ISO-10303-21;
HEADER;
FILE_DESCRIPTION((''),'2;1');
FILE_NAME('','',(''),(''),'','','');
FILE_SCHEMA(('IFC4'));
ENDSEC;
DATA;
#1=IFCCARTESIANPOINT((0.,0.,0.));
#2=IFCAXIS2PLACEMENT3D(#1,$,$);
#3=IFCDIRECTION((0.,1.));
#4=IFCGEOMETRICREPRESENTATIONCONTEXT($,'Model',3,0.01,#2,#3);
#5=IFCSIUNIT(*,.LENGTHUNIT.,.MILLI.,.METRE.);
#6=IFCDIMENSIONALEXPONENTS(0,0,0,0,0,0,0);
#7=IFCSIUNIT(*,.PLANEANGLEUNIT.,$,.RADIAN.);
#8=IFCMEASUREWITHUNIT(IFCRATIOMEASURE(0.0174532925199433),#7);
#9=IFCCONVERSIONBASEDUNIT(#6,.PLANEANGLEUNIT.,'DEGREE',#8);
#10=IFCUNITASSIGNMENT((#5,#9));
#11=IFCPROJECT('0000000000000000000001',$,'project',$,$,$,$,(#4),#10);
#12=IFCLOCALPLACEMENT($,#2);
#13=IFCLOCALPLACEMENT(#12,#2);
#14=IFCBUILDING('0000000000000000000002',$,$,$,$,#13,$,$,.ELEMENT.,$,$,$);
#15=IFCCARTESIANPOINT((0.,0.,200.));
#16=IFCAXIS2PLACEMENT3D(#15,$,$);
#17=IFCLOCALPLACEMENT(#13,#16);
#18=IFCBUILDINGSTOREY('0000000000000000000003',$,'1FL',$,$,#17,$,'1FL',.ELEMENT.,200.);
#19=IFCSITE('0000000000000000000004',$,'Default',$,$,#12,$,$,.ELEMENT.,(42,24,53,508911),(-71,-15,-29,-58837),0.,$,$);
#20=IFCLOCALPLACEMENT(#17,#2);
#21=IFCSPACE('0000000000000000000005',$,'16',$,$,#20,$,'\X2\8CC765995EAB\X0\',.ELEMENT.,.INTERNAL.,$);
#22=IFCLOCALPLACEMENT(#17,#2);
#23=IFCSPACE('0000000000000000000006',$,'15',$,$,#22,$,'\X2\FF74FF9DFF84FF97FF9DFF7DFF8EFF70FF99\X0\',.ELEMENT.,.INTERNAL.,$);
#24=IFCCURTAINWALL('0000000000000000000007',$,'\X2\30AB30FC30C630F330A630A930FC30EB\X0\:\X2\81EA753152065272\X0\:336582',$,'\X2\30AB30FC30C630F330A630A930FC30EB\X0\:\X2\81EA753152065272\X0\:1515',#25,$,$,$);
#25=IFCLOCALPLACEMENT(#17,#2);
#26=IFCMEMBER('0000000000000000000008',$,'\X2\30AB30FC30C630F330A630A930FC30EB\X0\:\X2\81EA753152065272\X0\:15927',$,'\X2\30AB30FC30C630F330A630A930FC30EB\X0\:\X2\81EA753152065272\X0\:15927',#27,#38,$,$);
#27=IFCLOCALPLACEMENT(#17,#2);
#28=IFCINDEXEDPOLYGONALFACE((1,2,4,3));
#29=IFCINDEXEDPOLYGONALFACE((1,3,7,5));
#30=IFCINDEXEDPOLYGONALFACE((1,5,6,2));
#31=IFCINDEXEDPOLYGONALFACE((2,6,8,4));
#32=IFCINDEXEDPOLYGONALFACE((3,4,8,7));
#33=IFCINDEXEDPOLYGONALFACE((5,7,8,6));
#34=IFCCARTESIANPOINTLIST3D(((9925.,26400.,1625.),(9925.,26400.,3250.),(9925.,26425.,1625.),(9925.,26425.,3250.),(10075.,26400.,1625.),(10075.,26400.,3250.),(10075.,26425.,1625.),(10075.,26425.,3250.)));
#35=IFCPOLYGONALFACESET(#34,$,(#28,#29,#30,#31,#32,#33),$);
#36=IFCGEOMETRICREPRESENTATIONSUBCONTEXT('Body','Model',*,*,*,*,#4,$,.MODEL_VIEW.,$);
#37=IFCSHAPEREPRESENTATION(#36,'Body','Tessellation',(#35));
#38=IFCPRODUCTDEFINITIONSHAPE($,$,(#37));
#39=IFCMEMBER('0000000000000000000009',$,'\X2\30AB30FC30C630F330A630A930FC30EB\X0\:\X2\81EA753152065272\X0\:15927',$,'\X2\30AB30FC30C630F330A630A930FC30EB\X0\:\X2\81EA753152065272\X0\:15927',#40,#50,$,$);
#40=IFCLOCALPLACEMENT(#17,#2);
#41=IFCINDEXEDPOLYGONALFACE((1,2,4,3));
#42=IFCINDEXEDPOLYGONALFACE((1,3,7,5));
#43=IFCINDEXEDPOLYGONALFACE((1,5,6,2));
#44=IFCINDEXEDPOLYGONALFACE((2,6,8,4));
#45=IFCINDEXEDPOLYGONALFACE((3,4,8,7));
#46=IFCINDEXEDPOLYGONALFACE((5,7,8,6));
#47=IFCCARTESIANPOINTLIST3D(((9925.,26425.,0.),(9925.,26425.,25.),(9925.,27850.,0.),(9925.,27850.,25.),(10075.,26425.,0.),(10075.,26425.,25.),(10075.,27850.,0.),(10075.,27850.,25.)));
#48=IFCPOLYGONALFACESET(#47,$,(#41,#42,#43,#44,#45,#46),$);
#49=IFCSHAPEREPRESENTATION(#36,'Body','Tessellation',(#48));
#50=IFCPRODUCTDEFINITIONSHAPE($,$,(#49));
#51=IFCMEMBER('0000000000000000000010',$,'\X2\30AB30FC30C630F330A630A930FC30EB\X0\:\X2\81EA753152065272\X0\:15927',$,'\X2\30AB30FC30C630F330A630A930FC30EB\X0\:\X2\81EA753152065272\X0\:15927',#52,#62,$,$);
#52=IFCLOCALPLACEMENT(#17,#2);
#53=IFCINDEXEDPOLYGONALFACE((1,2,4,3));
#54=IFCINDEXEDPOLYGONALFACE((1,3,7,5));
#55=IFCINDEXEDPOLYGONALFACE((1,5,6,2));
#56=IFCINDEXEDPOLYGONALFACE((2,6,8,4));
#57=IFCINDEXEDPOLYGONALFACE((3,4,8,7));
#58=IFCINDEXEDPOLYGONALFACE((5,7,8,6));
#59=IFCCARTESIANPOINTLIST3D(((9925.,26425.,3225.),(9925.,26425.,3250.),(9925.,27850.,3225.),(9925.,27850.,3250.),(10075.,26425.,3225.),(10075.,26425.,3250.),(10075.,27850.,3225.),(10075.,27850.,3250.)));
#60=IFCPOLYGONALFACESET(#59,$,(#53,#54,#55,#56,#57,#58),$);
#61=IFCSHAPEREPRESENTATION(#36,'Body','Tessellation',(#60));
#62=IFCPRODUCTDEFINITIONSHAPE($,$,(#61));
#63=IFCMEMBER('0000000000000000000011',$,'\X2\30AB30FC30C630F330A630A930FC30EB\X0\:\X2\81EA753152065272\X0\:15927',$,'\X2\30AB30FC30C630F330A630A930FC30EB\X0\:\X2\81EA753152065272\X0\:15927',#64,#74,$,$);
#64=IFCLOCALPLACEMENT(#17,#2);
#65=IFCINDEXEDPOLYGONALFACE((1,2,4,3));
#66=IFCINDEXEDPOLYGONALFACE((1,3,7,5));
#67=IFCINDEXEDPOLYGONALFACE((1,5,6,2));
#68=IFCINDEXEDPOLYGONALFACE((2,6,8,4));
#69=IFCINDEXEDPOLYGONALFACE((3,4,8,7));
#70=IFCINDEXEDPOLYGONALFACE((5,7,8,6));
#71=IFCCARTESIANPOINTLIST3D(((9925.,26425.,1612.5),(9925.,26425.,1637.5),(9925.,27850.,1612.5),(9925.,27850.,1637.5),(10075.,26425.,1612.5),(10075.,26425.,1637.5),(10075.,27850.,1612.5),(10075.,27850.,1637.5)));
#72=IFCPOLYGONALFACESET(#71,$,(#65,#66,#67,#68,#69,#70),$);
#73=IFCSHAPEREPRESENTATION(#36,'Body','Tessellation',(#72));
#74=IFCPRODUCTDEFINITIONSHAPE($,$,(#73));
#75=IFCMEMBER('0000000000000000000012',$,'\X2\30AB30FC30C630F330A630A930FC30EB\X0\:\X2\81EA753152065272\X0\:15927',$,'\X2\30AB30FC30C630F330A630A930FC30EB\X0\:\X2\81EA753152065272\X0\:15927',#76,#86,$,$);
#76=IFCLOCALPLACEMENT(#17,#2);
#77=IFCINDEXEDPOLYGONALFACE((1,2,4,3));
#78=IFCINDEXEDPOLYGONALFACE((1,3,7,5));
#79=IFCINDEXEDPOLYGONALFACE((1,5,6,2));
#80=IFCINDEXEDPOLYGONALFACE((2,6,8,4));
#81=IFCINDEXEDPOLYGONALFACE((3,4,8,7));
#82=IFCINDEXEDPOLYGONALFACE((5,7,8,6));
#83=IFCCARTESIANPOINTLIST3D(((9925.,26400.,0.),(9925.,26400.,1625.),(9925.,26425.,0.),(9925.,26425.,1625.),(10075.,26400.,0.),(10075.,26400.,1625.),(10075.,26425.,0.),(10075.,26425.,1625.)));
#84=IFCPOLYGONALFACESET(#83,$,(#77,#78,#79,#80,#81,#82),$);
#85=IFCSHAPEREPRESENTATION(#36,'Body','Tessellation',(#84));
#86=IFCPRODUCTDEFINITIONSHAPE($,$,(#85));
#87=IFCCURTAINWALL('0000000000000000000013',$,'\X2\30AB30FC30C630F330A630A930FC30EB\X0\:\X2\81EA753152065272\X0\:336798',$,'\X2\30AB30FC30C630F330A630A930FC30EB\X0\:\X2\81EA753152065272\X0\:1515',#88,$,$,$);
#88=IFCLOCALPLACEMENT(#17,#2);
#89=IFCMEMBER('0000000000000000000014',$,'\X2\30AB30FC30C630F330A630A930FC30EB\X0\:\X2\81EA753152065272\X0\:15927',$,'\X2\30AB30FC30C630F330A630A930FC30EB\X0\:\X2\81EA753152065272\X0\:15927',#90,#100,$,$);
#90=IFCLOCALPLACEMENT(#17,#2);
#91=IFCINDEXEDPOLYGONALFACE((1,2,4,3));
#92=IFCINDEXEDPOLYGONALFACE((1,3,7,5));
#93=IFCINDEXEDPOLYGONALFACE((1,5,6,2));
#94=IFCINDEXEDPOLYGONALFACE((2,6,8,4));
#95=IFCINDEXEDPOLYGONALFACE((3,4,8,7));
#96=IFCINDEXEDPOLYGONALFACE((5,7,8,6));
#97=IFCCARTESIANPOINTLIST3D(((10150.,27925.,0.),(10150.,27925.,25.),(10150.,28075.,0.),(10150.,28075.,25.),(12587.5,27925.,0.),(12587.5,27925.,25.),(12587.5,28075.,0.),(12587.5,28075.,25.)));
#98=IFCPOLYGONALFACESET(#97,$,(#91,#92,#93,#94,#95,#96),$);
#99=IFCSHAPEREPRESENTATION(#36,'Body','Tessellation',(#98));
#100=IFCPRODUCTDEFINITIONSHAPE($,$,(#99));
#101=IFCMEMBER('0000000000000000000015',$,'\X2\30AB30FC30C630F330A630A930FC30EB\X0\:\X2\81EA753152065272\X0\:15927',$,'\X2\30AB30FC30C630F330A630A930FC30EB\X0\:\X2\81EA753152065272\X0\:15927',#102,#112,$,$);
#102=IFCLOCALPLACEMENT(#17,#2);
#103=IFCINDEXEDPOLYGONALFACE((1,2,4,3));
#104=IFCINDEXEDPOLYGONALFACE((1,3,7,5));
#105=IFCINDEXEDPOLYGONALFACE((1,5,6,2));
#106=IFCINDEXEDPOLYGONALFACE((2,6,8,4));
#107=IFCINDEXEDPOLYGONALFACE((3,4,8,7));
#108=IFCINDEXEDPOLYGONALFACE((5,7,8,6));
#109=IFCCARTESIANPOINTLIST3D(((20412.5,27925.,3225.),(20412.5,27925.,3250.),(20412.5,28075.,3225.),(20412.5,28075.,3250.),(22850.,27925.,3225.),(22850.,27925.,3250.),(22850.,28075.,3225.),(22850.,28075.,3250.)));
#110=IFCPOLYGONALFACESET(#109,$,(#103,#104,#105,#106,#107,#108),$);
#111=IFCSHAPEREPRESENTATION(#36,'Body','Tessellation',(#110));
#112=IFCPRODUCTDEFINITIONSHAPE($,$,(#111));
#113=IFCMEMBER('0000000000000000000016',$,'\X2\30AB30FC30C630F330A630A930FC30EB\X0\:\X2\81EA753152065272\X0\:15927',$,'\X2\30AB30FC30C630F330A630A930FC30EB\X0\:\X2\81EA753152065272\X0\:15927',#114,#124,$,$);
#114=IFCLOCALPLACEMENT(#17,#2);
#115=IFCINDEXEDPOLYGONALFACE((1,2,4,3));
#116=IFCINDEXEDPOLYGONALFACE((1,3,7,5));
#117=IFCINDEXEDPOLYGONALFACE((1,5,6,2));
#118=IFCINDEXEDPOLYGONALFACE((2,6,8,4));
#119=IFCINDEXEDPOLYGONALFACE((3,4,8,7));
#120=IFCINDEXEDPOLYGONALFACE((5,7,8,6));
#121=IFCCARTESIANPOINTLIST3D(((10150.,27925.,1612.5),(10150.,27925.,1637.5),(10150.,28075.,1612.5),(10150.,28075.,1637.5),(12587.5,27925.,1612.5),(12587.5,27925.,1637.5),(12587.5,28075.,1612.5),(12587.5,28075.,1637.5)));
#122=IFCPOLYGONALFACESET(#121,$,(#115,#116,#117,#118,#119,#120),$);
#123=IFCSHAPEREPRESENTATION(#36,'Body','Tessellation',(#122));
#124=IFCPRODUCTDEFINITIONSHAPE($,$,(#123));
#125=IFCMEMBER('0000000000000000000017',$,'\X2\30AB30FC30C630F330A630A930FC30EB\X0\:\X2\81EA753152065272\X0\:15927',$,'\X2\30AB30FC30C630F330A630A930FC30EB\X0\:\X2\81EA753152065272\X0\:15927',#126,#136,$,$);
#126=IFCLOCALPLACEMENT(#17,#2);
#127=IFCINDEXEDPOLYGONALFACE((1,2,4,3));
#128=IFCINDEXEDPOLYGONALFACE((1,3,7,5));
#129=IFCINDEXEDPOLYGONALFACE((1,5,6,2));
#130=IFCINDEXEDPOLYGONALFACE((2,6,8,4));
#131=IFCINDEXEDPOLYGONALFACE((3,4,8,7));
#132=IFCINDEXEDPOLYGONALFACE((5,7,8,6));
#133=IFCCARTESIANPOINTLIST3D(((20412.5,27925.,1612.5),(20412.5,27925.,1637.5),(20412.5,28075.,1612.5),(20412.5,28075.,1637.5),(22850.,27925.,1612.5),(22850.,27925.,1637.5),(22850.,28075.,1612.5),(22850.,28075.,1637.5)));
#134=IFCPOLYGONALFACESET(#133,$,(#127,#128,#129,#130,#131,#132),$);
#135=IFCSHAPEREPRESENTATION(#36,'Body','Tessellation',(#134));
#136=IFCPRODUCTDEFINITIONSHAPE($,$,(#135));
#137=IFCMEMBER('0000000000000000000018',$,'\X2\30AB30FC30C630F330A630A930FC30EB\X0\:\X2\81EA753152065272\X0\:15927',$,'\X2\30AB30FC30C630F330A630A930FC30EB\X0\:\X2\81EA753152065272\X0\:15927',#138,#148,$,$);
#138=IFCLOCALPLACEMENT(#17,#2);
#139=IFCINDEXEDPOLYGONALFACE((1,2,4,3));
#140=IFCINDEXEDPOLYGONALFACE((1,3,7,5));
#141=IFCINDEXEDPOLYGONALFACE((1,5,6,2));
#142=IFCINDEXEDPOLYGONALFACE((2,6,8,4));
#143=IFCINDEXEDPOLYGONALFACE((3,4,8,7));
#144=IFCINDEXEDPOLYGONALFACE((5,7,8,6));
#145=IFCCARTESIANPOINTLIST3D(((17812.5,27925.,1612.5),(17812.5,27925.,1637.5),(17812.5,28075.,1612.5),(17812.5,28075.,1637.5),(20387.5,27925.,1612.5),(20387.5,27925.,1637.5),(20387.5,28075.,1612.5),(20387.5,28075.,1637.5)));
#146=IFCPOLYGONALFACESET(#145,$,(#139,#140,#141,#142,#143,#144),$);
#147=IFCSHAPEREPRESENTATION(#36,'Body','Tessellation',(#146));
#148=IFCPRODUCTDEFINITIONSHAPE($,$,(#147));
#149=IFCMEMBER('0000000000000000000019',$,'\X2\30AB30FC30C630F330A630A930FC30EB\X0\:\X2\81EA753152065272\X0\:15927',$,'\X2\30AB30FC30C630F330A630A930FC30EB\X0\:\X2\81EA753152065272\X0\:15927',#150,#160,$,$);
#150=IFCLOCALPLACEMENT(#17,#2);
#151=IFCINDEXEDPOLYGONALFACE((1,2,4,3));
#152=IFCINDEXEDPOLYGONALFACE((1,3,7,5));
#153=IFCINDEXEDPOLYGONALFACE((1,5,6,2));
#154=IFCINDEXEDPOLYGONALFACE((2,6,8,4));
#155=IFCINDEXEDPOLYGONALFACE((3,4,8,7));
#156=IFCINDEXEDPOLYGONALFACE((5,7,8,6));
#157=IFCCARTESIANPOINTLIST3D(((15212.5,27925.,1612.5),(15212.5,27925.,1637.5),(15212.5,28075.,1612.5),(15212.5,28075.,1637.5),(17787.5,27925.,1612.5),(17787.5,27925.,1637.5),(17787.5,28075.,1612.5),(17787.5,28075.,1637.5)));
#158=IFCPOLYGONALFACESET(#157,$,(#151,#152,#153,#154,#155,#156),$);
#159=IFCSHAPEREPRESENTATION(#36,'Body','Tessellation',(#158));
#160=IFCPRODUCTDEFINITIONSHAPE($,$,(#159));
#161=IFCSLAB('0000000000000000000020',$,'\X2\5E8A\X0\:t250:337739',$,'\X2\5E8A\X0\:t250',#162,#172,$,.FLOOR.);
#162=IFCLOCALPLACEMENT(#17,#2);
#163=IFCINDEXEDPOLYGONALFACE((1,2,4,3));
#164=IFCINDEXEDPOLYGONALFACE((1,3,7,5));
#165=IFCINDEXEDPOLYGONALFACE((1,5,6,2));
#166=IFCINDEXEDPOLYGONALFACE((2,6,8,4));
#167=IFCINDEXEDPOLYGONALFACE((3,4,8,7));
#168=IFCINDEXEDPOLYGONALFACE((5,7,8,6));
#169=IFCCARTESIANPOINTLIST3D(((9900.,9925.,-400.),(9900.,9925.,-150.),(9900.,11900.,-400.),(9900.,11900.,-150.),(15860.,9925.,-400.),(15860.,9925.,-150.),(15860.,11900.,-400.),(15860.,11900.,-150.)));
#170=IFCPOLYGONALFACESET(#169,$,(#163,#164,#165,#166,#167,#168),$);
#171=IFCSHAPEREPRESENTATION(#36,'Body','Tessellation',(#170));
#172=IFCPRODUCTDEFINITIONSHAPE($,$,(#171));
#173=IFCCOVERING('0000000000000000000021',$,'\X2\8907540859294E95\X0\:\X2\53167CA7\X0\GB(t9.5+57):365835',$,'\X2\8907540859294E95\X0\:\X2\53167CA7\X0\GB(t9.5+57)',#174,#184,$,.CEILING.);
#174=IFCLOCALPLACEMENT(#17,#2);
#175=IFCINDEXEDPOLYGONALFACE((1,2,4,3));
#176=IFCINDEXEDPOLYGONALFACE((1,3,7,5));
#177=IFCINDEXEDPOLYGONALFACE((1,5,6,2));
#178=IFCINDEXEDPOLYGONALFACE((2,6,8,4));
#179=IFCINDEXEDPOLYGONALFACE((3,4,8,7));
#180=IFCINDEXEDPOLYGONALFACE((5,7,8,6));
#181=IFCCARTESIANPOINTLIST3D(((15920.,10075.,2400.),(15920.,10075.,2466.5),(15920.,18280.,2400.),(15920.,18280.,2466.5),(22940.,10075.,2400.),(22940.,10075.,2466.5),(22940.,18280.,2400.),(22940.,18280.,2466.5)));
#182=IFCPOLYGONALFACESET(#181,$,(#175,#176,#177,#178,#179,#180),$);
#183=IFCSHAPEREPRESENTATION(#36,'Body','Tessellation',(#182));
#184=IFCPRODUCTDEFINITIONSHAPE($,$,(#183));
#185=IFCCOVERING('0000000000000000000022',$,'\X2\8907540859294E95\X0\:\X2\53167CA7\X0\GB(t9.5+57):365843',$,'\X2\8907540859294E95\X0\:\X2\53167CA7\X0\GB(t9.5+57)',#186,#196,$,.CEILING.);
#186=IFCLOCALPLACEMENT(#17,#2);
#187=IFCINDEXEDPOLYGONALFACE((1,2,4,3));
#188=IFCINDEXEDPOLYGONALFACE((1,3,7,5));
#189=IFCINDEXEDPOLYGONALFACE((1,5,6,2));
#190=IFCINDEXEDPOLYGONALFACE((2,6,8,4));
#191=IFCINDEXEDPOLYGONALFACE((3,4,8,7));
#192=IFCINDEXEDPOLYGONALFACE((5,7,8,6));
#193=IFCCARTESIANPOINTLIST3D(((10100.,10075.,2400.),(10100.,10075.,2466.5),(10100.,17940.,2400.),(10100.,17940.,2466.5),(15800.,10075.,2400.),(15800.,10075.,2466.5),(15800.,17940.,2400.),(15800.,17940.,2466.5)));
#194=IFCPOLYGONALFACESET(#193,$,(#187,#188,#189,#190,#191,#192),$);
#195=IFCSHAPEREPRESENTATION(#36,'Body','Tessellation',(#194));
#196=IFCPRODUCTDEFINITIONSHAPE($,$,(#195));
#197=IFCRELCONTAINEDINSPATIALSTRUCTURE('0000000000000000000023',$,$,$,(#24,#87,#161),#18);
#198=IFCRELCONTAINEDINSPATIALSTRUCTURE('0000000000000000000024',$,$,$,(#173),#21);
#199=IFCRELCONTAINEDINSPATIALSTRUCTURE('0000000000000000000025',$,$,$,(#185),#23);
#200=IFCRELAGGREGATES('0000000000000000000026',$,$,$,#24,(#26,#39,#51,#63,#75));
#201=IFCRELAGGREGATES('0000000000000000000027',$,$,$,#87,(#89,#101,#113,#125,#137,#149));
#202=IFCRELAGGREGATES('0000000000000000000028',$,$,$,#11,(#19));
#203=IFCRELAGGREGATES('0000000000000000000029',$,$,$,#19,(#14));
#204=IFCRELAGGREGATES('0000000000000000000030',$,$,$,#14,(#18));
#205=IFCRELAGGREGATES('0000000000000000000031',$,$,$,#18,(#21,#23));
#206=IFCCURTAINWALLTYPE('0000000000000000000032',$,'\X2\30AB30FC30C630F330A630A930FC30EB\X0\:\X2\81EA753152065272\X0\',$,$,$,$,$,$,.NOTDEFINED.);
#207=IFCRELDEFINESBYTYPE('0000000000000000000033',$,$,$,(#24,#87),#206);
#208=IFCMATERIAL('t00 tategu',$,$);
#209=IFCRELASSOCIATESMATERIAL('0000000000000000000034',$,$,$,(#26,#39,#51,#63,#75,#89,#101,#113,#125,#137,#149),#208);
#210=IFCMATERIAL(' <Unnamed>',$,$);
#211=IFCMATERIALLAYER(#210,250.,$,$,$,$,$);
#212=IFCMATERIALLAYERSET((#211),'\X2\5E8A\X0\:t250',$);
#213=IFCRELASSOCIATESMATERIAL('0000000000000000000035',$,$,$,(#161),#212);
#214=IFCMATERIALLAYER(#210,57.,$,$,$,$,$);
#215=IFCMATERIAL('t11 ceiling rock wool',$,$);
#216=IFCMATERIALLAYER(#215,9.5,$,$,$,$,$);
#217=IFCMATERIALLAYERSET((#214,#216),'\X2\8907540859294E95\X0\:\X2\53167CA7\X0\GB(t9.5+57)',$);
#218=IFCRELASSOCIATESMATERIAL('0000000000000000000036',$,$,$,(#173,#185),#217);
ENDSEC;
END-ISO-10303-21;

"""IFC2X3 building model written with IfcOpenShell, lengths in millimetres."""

from ifc_helpers import new_model, entity, si_unit, converted_unit, direction, frame, frame_2d, origin, origin_2d_with_axis, place, context, subcontext, project, spatial, rectangle, extrude, material, layer, layer_set, layer_usage, type_object, element, aggregate, save


model = new_model("IFC2X3")

# Units and contexts
model_context = context("Model", 3, precision=0.01, world=origin(), true_north=direction((0.0, 1.0)))
body_context = subcontext(model_context, "Body", "Model", "MODEL_VIEW")
ifc_project = project(units=[si_unit("LENGTHUNIT", "METRE", prefix="MILLI"), converted_unit("PLANEANGLEUNIT", "DEGREE", entity("IfcRatioMeasure", 0.0174532925199433), si_unit("PLANEANGLEUNIT", "RADIAN"), dimensions=[0, 0, 0, 0, 0, 0, 0])], contexts=[model_context])

# Site, building, storey
site_placement = place(None, origin())
site = spatial("IfcSite", under=ifc_project, at=site_placement, Name="Default", CompositionType="ELEMENT", RefLatitude=(42, 24, 53, 508911), RefLongitude=(-71, -15, -29, -58837), RefElevation=0.0)
building_placement = place(site_placement, origin())
building = spatial("IfcBuilding", under=site, at=building_placement, CompositionType="ELEMENT")
storey_placement = place(building_placement, frame((0.0, 0.0, 200.0)))
storey = spatial("IfcBuildingStorey", under=building, at=storey_placement, Name="1FL", LongName="1FL", CompositionType="ELEMENT", Elevation=200.0)

# Curtain walls, members
curtain_wall_type = type_object("IfcCurtainWallType", Name="カーテンウォール:自由分割", PredefinedType="NOTDEFINED")
curtain_wall_1_placement = place(storey_placement, frame((0.0, 0.0, -200.0)))
curtain_wall_1 = element("IfcCurtainWall", 1, at=curtain_wall_1_placement, inside=storey, type_object=curtain_wall_type, Name="カーテンウォール:自由分割:336582", ObjectType="カーテンウォール:自由分割:1515")
ifc_material_1 = material(Name="t00 tategu")
member_1_placement = place(curtain_wall_1_placement, frame((0.0, 0.0, 200.0)))
member_1 = element("IfcMember", 2, at=member_1_placement, material=ifc_material_1, Name="カーテンウォール:自由分割:15927", ObjectType="カーテンウォール:自由分割:15927", context=body_context, shape_type="SweptSolid", body=[
    extrude(rectangle(XDim=150.0, YDim=25.0, at=frame_2d((0.0, 0.0), x_axis=(1.0, 0.0))), frame((10000.0, 26412.5, 3250.0), z_axis=(0.0, 0.0, -1.0), x_axis=(-1.0, 0.0, 0.0)), (0.0, 0.0, 1.0), 1625.0),
])
member_2_placement = place(curtain_wall_1_placement, frame((0.0, 0.0, 200.0)))
member_2 = element("IfcMember", 3, at=member_2_placement, material=ifc_material_1, Name="カーテンウォール:自由分割:15927", ObjectType="カーテンウォール:自由分割:15927", context=body_context, shape_type="SweptSolid", body=[
    extrude(rectangle(XDim=25.0, YDim=150.0, at=origin_2d_with_axis()), frame((10000.0, 26425.0, 12.5), z_axis=(0.0, 1.0, 0.0), x_axis=(0.0, 0.0, -1.0)), (0.0, 0.0, 1.0), 1425.0),
])
member_3_placement = place(curtain_wall_1_placement, frame((0.0, 0.0, 200.0)))
member_3 = element("IfcMember", 4, at=member_3_placement, material=ifc_material_1, Name="カーテンウォール:自由分割:15927", ObjectType="カーテンウォール:自由分割:15927", context=body_context, shape_type="SweptSolid", body=[
    extrude(rectangle(XDim=25.0, YDim=150.0, at=frame_2d((0.0, 0.0), x_axis=(1.0, 0.0))), frame((10000.0, 27850.0, 3237.5), z_axis=(0.0, -1.0, 0.0), x_axis=(0.0, 0.0, -1.0)), (0.0, 0.0, 1.0), 1425.0),
])
member_4_placement = place(curtain_wall_1_placement, frame((0.0, 0.0, 200.0)))
member_4 = element("IfcMember", 5, at=member_4_placement, material=ifc_material_1, Name="カーテンウォール:自由分割:15927", ObjectType="カーテンウォール:自由分割:15927", context=body_context, shape_type="SweptSolid", body=[
    extrude(rectangle(XDim=25.0, YDim=150.0, at=origin_2d_with_axis()), frame((10000.0, 27850.0, 1625.0), z_axis=(0.0, -1.0, 0.0), x_axis=(0.0, 0.0, -1.0)), (0.0, 0.0, 1.0), 1425.0),
])
member_5_placement = place(curtain_wall_1_placement, frame((0.0, 0.0, 200.0)))
member_5 = element("IfcMember", 6, at=member_5_placement, material=ifc_material_1, Name="カーテンウォール:自由分割:15927", ObjectType="カーテンウォール:自由分割:15927", context=body_context, shape_type="SweptSolid", body=[
    extrude(rectangle(XDim=150.0, YDim=25.0, at=frame_2d((0.0, 0.0), x_axis=(1.0, 0.0))), frame((10000.0, 26412.5, 1625.0), z_axis=(0.0, 0.0, -1.0), x_axis=(-1.0, 0.0, 0.0)), (0.0, 0.0, 1.0), 1625.0),
])
aggregate(curtain_wall_1, [member_1, member_2, member_3, member_4, member_5])
curtain_wall_2_placement = place(storey_placement, frame((0.0, 0.0, -200.0)))
curtain_wall_2 = element("IfcCurtainWall", 7, at=curtain_wall_2_placement, inside=storey, type_object=curtain_wall_type, Name="カーテンウォール:自由分割:336798", ObjectType="カーテンウォール:自由分割:1515")
member_6_placement = place(curtain_wall_2_placement, frame((0.0, 0.0, 200.0)))
member_6 = element("IfcMember", 8, at=member_6_placement, material=ifc_material_1, Name="カーテンウォール:自由分割:15927", ObjectType="カーテンウォール:自由分割:15927", context=body_context, shape_type="SweptSolid", body=[
    extrude(rectangle(XDim=25.0, YDim=150.0, at=frame_2d((0.0, 0.0), x_axis=(1.0, 0.0))), frame((10150.0, 28000.0, 12.5), z_axis=(1.0, 0.0, 0.0), x_axis=(0.0, 0.0, -1.0)), (0.0, 0.0, 1.0), 2437.5),
])
member_7_placement = place(curtain_wall_2_placement, frame((0.0, 0.0, 200.0)))
member_7 = element("IfcMember", 9, at=member_7_placement, material=ifc_material_1, Name="カーテンウォール:自由分割:15927", ObjectType="カーテンウォール:自由分割:15927", context=body_context, shape_type="SweptSolid", body=[
    extrude(rectangle(XDim=25.0, YDim=150.0, at=frame_2d((0.0, 0.0), x_axis=(1.0, 0.0))), frame((22850.0, 28000.0, 3237.5), z_axis=(-1.0, 0.0, 0.0), x_axis=(0.0, 0.0, -1.0)), (0.0, 0.0, 1.0), 2437.5),
])
member_8_placement = place(curtain_wall_2_placement, frame((0.0, 0.0, 200.0)))
member_8 = element("IfcMember", 10, at=member_8_placement, material=ifc_material_1, Name="カーテンウォール:自由分割:15927", ObjectType="カーテンウォール:自由分割:15927", context=body_context, shape_type="SweptSolid", body=[
    extrude(rectangle(XDim=25.0, YDim=150.0, at=frame_2d((0.0, 0.0), x_axis=(1.0, 0.0))), frame((12587.5, 28000.0, 1625.0), z_axis=(-1.0, 0.0, 0.0), x_axis=(0.0, 0.0, -1.0)), (0.0, 0.0, 1.0), 2437.5),
])
member_9_placement = place(curtain_wall_2_placement, frame((0.0, 0.0, 200.0)))
member_9 = element("IfcMember", 11, at=member_9_placement, material=ifc_material_1, Name="カーテンウォール:自由分割:15927", ObjectType="カーテンウォール:自由分割:15927", context=body_context, shape_type="SweptSolid", body=[
    extrude(rectangle(XDim=25.0, YDim=150.0, at=frame_2d((0.0, 0.0), x_axis=(1.0, 0.0))), frame((22850.0, 28000.0, 1625.0), z_axis=(-1.0, 0.0, 0.0), x_axis=(0.0, 0.0, -1.0)), (0.0, 0.0, 1.0), 2437.5),
])
member_10_placement = place(curtain_wall_2_placement, frame((0.0, 0.0, 200.0)))
member_10 = element("IfcMember", 12, at=member_10_placement, material=ifc_material_1, Name="カーテンウォール:自由分割:15927", ObjectType="カーテンウォール:自由分割:15927", context=body_context, shape_type="SweptSolid", body=[
    extrude(rectangle(XDim=25.0, YDim=150.0, at=frame_2d((0.0, 0.0), x_axis=(1.0, 0.0))), frame((20387.5, 28000.0, 1625.0), z_axis=(-1.0, 0.0, 0.0), x_axis=(0.0, 0.0, -1.0)), (0.0, 0.0, 1.0), 2575.0),
])
member_11_placement = place(curtain_wall_2_placement, frame((0.0, 0.0, 200.0)))
member_11 = element("IfcMember", 13, at=member_11_placement, material=ifc_material_1, Name="カーテンウォール:自由分割:15927", ObjectType="カーテンウォール:自由分割:15927", context=body_context, shape_type="SweptSolid", body=[
    extrude(rectangle(XDim=25.0, YDim=150.0, at=frame_2d((0.0, 0.0), x_axis=(1.0, 0.0))), frame((17787.5, 28000.0, 1625.0), z_axis=(-1.0, 0.0, 0.0), x_axis=(0.0, 0.0, -1.0)), (0.0, 0.0, 1.0), 2575.0),
])
aggregate(curtain_wall_2, [member_6, member_7, member_8, member_9, member_10, member_11])

# Slab
ifc_material_2 = material(Name=" <Unnamed>")
ifc_layer_1 = layer(ifc_material_2, 250.0)
ifc_layer_set_1 = layer_set([ifc_layer_1], Name="床:t250")
ifc_layer_usage_1 = layer_usage(ifc_layer_set_1, "AXIS3", "POSITIVE", 0.0)
slab_1_placement = place(storey_placement, origin())
element("IfcSlab", 14, at=slab_1_placement, inside=storey, material=ifc_layer_usage_1, Name="床:t250:337739", ObjectType="床:t250", PredefinedType="FLOOR", context=body_context, shape_type="SweptSolid", body=[
    extrude(rectangle(XDim=1975.0, YDim=5960.0, at=frame_2d((0.0, 0.0), x_axis=(1.0, 0.0))), frame((12880.0, 10912.5, -150.0), z_axis=(0.0, 0.0, -1.0), x_axis=(0.0, 1.0, 0.0)), (0.0, 0.0, 1.0), 250.0),
])

# Shared definitions
space_1_placement = place(storey_placement, origin())
space_1 = spatial("IfcSpace", under=storey, at=space_1_placement, Name="16", LongName="資料庫", CompositionType="ELEMENT", InteriorOrExteriorSpace="INTERNAL")

# Covering
ifc_layer_2 = layer(ifc_material_2, 57.0)
ifc_material_3 = material(Name="t11 ceiling rock wool")
ifc_layer_3 = layer(ifc_material_3, 9.5)
ifc_layer_set_2 = layer_set([ifc_layer_2, ifc_layer_3], Name="複合天井:化粧GB(t9.5+57)")
ifc_layer_usage_2 = layer_usage(ifc_layer_set_2, "AXIS3", "NEGATIVE", 0.0)
covering_1_placement = place(space_1_placement, origin())
element("IfcCovering", 15, at=covering_1_placement, inside=space_1, material=ifc_layer_usage_2, Name="複合天井:化粧GB(t9.5+57):365835", ObjectType="複合天井:化粧GB(t9.5+57)", PredefinedType="CEILING", context=body_context, shape_type="SweptSolid", body=[
    extrude(rectangle(XDim=7020.0, YDim=8205.0, at=frame_2d((0.0, 0.0), x_axis=(1.0, 0.0))), frame((19430.0, 14177.5, 2400.0), z_axis=(0.0, 0.0, 1.0), x_axis=(-1.0, 0.0, 0.0)), (0.0, 0.0, 1.0), 66.5),
])

# Shared definitions
space_2_placement = place(storey_placement, origin())
space_2 = spatial("IfcSpace", under=storey, at=space_2_placement, Name="15", LongName="ｴﾝﾄﾗﾝｽﾎｰﾙ", CompositionType="ELEMENT", InteriorOrExteriorSpace="INTERNAL")

# Covering
ifc_layer_usage_3 = layer_usage(ifc_layer_set_2, "AXIS3", "NEGATIVE", 0.0)
covering_2_placement = place(space_2_placement, origin())
element("IfcCovering", 16, at=covering_2_placement, inside=space_2, material=ifc_layer_usage_3, Name="複合天井:化粧GB(t9.5+57):365843", ObjectType="複合天井:化粧GB(t9.5+57)", PredefinedType="CEILING", context=body_context, shape_type="SweptSolid", body=[
    extrude(rectangle(XDim=7865.0, YDim=5700.0, at=frame_2d((0.0, 0.0), x_axis=(1.0, 0.0))), frame((12950.0, 14007.5, 2400.0), z_axis=(0.0, 0.0, 1.0), x_axis=(0.0, 1.0, 0.0)), (0.0, 0.0, 1.0), 66.5),
])

save(model, "model.ifc")
